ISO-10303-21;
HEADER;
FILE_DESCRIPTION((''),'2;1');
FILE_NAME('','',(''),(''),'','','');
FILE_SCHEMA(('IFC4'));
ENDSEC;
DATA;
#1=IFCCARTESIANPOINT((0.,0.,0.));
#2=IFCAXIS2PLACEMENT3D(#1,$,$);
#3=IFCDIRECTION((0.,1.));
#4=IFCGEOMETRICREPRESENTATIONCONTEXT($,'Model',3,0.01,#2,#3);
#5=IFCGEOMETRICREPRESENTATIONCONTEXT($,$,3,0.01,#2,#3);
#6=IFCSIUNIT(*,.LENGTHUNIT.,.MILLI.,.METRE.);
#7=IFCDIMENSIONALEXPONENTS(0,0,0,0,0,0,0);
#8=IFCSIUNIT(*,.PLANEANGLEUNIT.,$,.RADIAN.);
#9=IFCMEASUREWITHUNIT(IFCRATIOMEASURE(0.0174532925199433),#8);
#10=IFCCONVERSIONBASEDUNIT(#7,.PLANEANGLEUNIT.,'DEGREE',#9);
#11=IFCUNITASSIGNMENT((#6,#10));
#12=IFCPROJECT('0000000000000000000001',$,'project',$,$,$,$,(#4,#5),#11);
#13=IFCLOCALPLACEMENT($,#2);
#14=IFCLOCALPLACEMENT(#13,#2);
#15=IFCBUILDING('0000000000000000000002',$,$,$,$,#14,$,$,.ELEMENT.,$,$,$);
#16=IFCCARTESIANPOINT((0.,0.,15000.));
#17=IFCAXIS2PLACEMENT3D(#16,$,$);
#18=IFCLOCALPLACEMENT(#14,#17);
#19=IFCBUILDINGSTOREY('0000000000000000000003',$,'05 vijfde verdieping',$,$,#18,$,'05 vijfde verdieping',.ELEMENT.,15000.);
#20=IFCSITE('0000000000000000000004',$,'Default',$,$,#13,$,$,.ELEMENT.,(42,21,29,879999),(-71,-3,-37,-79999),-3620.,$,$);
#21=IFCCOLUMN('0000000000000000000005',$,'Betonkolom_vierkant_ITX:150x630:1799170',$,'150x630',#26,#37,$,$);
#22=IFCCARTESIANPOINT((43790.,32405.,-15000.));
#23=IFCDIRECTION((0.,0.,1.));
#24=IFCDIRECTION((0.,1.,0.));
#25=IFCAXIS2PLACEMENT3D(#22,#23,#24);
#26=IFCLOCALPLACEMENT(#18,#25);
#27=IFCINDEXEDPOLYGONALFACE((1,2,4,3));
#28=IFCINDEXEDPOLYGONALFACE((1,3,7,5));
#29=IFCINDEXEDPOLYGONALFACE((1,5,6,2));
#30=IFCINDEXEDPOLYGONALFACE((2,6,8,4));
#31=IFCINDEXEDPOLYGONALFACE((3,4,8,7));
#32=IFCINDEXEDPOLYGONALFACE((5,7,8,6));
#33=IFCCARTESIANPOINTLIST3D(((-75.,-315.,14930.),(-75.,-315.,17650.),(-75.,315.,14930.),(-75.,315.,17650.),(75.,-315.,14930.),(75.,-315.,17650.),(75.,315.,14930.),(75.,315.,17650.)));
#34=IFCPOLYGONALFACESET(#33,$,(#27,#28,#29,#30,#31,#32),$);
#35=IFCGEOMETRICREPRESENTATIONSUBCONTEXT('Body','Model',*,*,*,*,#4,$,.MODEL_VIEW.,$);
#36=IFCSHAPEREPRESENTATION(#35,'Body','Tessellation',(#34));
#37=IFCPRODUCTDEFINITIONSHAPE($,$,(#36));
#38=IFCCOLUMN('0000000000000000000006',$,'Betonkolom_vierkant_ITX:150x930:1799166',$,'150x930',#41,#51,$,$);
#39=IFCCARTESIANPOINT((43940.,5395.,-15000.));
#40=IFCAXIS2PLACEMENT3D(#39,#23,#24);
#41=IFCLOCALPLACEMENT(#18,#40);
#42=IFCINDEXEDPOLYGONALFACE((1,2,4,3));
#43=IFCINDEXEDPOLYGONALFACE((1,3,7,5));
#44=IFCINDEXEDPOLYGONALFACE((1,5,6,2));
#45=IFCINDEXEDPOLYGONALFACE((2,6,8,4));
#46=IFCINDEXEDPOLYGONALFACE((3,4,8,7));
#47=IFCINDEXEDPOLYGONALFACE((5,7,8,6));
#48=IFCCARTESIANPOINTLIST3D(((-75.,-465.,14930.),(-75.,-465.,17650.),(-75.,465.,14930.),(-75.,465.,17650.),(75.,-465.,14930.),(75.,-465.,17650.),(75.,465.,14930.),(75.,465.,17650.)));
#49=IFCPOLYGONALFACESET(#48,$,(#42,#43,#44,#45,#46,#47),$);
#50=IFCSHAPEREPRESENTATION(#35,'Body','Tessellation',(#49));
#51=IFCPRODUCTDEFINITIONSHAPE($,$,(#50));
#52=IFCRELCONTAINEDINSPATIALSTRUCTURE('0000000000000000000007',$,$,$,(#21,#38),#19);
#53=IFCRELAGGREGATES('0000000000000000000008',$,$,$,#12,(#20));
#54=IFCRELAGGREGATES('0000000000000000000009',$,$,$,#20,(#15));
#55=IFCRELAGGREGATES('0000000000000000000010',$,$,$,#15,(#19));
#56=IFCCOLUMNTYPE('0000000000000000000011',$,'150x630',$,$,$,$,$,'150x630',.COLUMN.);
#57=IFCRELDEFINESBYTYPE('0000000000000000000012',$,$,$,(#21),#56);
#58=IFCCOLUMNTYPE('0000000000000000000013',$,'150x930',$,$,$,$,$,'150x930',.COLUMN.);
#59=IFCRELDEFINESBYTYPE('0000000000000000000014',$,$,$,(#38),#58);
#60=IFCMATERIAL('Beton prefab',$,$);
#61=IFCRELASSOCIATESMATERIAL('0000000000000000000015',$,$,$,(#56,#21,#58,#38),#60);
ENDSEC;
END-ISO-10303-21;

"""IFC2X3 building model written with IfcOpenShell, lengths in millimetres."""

from ifc_helpers import new_model, entity, si_unit, converted_unit, direction, frame, origin, origin_2d_with_axis, place, context, subcontext, project, spatial, rectangle, extrude, source, transform, mapped, material, type_object, type_shapes, element, save


model = new_model("IFC2X3")

# Units and contexts
model_context = context("Model", 3, precision=0.01, world=origin(), true_north=direction((0.0, 1.0)))
context_of_model = context(None, 3, precision=0.01, world=origin(), true_north=direction((0.0, 1.0)))
body_context = subcontext(model_context, "Body", "Model", "MODEL_VIEW")
ifc_project = project(units=[si_unit("LENGTHUNIT", "METRE", prefix="MILLI"), converted_unit("PLANEANGLEUNIT", "DEGREE", entity("IfcRatioMeasure", 0.0174532925199433), si_unit("PLANEANGLEUNIT", "RADIAN"), dimensions=[0, 0, 0, 0, 0, 0, 0])], contexts=[model_context, context_of_model])

# Site, building, storey
site_placement = place(None, origin())
site = spatial("IfcSite", under=ifc_project, at=site_placement, Name="Default", CompositionType="ELEMENT", RefLatitude=(42, 21, 29, 879999), RefLongitude=(-71, -3, -37, -79999), RefElevation=-3620.0)
building_placement = place(site_placement, origin())
building = spatial("IfcBuilding", under=site, at=building_placement, CompositionType="ELEMENT")
storey_placement = place(building_placement, frame((0.0, 0.0, 15000.0)))
storey = spatial("IfcBuildingStorey", under=building, at=storey_placement, Name="05 vijfde verdieping", LongName="05 vijfde verdieping", CompositionType="ELEMENT", Elevation=15000.0)

# Columns
ifc_material_1 = material(Name="Beton prefab")
column_type_1 = type_object("IfcColumnType", Name="150x630", ElementType="150x630", PredefinedType="COLUMN", material=ifc_material_1)
shared_shape_1 = source(origin(), body_context, "Body", "SweptSolid", [
    extrude(rectangle(XDim=630.0, YDim=150.0, at=origin_2d_with_axis()), frame((0.0, 0.0, 14930.0), z_axis=(0.0, 0.0, 1.0), x_axis=(0.0, -1.0, 0.0)), (0.0, 0.0, 1.0), 2720.0),
])
type_shapes(column_type_1, [shared_shape_1])
column_1_placement = place(storey_placement, frame((43790.0, 32405.0, -15000.0), z_axis=(0.0, 0.0, 1.0), x_axis=(0.0, 1.0, 0.0)))
element("IfcColumn", 1, at=column_1_placement, inside=storey, type_object=column_type_1, material=ifc_material_1, Name="Betonkolom_vierkant_ITX:150x630:1799170", ObjectType="150x630", context=body_context, shape_type="MappedRepresentation", body=[
    mapped(shared_shape_1, transform((0.0, 0.0, 0.0), scale=1.0)),
])
column_type_2 = type_object("IfcColumnType", Name="150x930", ElementType="150x930", PredefinedType="COLUMN", material=ifc_material_1)
shared_shape_2 = source(origin(), body_context, "Body", "SweptSolid", [
    extrude(rectangle(XDim=930.0, YDim=150.0, at=origin_2d_with_axis()), frame((0.0, 0.0, 14930.0), z_axis=(0.0, 0.0, 1.0), x_axis=(0.0, -1.0, 0.0)), (0.0, 0.0, 1.0), 2720.0),
])
type_shapes(column_type_2, [shared_shape_2])
column_2_placement = place(storey_placement, frame((43940.0, 5395.0, -15000.0), z_axis=(0.0, 0.0, 1.0), x_axis=(0.0, 1.0, 0.0)))
element("IfcColumn", 2, at=column_2_placement, inside=storey, type_object=column_type_2, material=ifc_material_1, Name="Betonkolom_vierkant_ITX:150x930:1799166", ObjectType="150x930", context=body_context, shape_type="MappedRepresentation", body=[
    mapped(shared_shape_2, transform((0.0, 0.0, 0.0), scale=1.0)),
])

save(model, "model.ifc")
